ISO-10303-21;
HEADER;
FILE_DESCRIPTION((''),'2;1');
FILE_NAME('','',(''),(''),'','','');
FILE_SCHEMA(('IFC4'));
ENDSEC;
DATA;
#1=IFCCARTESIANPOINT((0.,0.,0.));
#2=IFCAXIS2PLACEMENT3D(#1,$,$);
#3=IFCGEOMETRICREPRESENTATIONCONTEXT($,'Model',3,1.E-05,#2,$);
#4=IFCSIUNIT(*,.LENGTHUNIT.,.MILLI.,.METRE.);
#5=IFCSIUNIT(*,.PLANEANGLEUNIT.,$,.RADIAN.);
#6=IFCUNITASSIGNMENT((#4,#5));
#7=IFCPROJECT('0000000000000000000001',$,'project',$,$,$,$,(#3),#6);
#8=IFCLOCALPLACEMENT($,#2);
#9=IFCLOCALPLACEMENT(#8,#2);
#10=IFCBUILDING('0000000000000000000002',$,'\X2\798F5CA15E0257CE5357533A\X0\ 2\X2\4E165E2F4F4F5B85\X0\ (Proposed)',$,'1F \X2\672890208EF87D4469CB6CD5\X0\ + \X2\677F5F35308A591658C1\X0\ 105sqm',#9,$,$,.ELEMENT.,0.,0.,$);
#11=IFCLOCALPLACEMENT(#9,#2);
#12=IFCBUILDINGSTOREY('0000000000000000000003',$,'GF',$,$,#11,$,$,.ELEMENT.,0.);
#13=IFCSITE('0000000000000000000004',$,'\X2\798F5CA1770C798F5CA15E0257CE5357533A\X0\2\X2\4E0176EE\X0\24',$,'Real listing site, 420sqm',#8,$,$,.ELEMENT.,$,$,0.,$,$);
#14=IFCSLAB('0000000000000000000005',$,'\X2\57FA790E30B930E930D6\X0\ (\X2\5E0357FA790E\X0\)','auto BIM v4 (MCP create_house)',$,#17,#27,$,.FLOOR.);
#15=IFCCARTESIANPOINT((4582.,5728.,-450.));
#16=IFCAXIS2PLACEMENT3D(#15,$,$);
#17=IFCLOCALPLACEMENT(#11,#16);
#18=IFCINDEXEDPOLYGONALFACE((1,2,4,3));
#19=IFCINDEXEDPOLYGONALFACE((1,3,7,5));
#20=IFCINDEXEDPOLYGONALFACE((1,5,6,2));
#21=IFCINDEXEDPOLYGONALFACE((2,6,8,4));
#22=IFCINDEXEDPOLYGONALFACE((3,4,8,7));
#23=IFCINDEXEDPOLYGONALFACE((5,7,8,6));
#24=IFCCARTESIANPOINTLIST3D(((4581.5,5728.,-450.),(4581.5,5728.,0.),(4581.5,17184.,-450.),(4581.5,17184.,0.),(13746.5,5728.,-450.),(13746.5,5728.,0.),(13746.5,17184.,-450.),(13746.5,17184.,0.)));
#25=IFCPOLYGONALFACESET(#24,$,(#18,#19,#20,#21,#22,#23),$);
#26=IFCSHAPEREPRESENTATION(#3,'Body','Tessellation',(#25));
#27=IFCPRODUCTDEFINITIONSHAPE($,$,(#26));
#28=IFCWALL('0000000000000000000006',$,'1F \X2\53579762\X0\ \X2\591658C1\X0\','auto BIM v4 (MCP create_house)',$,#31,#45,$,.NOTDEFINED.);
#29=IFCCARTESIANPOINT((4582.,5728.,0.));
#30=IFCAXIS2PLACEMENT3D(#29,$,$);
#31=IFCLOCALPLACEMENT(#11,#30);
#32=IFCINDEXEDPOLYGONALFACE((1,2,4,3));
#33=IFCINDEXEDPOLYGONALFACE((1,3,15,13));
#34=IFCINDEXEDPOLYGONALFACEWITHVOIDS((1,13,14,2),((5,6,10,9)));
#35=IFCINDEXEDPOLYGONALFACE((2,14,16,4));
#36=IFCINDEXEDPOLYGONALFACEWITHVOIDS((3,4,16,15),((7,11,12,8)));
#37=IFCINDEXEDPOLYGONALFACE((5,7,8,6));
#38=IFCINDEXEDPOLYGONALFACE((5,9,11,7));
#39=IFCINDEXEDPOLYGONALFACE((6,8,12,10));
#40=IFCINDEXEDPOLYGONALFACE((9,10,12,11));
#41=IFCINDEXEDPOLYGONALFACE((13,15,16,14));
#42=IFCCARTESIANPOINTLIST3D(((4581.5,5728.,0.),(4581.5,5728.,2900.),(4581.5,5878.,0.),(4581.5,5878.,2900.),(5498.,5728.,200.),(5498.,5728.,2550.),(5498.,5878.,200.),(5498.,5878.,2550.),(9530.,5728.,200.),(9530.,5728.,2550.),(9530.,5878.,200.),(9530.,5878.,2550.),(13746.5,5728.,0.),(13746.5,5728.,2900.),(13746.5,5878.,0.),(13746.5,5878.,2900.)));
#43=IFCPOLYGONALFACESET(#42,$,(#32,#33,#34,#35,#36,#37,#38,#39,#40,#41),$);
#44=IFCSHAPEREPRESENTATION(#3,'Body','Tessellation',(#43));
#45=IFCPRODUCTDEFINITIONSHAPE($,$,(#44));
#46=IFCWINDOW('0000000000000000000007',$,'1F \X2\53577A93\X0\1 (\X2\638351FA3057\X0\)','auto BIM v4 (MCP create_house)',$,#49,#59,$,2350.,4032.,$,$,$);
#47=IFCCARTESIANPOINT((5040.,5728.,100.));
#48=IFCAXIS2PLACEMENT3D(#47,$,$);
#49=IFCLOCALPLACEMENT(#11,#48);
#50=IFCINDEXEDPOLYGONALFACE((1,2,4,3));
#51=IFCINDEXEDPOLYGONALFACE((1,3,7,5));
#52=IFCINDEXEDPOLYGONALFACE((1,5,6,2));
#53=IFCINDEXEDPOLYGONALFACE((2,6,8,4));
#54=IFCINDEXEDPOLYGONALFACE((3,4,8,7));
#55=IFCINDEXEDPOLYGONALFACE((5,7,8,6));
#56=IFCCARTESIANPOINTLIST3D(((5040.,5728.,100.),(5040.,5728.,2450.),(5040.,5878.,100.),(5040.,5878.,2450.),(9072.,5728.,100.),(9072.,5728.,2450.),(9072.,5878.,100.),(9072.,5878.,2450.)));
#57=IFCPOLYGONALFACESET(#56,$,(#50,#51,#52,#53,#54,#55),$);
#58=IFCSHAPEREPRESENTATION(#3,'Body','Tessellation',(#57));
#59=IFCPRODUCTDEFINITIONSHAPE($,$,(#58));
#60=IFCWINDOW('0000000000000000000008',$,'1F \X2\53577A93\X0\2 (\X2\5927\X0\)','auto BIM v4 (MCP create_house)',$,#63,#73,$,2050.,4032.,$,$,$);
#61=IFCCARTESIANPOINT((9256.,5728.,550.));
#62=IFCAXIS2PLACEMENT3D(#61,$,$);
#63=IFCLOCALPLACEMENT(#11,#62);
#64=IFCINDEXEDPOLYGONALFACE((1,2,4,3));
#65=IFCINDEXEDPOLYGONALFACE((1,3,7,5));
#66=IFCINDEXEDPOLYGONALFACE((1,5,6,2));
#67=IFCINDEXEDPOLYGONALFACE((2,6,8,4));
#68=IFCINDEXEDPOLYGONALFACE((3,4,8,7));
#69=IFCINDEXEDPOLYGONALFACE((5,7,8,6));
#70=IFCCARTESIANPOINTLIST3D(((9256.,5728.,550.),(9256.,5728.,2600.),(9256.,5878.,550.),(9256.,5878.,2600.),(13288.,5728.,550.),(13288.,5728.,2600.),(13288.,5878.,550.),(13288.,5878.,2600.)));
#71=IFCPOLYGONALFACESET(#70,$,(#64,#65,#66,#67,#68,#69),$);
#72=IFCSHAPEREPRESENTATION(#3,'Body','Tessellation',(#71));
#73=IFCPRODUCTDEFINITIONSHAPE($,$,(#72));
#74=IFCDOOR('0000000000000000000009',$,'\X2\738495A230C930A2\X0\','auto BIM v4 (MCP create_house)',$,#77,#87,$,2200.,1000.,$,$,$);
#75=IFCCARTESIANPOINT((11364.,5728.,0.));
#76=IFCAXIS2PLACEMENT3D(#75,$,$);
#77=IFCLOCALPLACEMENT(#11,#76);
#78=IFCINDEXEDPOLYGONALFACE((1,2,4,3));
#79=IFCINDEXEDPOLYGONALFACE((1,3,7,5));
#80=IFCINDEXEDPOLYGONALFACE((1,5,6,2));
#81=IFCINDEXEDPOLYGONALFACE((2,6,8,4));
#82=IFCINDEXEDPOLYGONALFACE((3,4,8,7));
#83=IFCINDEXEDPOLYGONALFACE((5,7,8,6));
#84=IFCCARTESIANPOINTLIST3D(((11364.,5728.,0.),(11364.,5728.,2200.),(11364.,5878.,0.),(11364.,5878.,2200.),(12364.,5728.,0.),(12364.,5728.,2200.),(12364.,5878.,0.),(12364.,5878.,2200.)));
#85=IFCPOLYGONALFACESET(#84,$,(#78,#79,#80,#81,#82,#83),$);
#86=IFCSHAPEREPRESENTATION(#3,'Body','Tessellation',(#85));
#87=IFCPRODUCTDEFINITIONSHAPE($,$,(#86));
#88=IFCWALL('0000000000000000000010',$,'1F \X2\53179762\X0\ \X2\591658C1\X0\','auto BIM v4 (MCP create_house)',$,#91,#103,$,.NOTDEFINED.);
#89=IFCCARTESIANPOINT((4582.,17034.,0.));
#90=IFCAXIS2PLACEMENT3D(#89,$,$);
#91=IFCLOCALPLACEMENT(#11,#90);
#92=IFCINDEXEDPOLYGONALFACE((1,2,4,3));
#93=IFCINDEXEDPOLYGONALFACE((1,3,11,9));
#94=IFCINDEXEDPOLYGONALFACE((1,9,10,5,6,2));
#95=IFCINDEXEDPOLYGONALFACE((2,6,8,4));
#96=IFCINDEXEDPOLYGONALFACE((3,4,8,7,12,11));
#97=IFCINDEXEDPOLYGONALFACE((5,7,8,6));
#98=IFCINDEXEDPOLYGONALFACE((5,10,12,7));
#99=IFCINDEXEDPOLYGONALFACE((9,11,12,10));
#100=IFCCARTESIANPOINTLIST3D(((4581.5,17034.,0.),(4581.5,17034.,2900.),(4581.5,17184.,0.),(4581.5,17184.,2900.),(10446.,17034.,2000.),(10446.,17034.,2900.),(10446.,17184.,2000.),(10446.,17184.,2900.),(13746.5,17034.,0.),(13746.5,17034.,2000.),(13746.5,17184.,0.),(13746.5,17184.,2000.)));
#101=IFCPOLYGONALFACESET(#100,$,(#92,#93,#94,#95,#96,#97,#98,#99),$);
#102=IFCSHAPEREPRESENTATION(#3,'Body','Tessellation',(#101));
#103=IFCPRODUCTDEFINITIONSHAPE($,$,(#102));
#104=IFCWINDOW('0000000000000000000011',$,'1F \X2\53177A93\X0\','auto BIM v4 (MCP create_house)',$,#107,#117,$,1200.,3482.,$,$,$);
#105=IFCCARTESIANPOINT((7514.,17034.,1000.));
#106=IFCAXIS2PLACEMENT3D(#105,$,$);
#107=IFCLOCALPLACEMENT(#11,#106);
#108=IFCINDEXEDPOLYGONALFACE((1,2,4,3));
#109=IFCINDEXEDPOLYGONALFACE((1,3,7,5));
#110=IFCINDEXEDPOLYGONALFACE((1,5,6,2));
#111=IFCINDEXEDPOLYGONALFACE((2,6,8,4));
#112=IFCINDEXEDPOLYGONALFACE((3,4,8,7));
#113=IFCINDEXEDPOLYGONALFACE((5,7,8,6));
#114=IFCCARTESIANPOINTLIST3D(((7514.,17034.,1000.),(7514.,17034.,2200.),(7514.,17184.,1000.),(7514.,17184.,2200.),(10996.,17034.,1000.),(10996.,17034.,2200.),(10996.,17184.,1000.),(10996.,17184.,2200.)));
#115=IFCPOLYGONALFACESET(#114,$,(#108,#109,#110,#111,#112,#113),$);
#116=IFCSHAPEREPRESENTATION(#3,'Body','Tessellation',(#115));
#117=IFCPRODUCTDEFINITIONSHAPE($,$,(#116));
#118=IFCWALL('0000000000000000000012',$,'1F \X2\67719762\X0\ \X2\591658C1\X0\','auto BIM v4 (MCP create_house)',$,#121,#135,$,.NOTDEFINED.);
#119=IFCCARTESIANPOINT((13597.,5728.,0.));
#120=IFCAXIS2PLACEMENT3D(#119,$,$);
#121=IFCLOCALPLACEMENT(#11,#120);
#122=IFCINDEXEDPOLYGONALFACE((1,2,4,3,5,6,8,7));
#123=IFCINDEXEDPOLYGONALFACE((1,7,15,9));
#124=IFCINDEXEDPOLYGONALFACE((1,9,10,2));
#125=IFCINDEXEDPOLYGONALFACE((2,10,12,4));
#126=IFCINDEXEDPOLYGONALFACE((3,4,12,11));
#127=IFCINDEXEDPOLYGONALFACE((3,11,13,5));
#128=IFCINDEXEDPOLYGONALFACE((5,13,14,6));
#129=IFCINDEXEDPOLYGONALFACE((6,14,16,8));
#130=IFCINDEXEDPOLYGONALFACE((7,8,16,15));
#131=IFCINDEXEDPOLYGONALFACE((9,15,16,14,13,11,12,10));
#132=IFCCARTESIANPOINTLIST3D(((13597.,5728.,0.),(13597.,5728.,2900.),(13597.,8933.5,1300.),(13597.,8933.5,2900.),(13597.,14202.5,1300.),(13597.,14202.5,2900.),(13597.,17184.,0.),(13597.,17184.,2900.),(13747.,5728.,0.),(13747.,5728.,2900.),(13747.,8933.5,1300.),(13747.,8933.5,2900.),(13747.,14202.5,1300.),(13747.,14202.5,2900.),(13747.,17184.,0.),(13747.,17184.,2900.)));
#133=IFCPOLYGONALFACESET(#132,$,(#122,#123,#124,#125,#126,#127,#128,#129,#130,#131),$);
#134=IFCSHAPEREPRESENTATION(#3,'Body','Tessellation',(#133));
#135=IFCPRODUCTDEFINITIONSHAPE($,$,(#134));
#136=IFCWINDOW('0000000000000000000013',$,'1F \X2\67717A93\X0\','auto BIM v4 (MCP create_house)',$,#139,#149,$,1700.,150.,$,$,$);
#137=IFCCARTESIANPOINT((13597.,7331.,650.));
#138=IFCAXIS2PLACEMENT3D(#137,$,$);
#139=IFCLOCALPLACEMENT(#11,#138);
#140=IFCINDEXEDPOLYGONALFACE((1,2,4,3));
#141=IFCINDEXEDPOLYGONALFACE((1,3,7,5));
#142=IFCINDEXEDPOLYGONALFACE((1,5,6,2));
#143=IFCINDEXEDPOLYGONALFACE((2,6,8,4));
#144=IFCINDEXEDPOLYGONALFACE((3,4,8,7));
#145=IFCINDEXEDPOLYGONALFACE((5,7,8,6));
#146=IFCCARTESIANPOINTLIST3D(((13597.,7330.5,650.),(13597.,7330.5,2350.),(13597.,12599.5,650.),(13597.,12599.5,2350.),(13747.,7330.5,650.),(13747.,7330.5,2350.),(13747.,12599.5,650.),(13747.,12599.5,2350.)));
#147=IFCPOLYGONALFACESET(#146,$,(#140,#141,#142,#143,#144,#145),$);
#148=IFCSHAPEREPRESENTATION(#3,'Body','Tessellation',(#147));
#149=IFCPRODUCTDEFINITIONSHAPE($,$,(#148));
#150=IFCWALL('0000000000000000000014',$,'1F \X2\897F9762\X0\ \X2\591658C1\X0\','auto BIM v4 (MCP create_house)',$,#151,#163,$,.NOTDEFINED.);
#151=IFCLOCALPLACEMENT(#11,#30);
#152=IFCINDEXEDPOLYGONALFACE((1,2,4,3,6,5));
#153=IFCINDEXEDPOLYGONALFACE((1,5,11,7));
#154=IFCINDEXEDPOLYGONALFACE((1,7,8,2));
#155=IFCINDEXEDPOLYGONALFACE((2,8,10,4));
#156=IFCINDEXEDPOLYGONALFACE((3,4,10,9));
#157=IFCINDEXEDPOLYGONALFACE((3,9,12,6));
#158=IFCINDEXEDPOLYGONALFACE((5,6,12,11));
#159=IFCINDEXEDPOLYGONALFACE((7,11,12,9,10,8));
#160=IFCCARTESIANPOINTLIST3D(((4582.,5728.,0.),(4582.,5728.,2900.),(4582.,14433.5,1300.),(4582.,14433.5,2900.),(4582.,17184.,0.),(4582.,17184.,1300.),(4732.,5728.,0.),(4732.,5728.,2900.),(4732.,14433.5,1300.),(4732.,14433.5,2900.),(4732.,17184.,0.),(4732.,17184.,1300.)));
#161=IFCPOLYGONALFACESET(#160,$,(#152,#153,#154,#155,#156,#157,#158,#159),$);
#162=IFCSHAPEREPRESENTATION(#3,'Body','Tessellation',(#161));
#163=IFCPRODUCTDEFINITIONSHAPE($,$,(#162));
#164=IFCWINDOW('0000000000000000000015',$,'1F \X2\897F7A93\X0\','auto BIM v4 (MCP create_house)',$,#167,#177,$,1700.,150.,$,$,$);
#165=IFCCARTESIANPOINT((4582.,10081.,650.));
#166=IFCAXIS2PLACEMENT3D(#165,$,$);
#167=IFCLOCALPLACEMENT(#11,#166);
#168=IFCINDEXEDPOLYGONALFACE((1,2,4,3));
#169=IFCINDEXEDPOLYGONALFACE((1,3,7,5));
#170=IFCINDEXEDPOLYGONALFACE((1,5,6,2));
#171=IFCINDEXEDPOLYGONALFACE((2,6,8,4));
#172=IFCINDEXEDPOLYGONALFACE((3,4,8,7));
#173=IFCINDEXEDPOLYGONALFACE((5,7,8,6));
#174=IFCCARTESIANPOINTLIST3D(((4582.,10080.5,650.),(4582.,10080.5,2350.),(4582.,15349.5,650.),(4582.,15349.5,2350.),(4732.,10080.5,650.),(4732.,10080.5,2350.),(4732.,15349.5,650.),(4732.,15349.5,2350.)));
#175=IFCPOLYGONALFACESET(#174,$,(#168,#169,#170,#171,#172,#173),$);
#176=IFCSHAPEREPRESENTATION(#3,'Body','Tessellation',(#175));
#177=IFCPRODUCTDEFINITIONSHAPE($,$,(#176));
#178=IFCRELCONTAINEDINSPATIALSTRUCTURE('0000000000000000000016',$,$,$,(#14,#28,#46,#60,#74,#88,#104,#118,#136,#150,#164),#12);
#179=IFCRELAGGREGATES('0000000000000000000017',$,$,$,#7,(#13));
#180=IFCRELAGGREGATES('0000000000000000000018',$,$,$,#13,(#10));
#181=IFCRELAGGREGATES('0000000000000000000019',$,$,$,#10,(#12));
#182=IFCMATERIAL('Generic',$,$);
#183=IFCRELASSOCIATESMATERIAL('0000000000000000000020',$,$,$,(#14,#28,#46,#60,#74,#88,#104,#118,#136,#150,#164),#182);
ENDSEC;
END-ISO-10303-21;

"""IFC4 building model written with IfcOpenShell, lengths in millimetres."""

from ifc_helpers import new_model, si_unit, frame, frame_2d, origin, place, context, project, spatial, rectangle, extrude, material, element, fill, save


model = new_model("IFC4")

# Units and contexts
model_context = context("Model", 3, precision=1e-05, world=origin())
ifc_project = project(units=[si_unit("LENGTHUNIT", "METRE", prefix="MILLI"), si_unit("PLANEANGLEUNIT", "RADIAN")], contexts=[model_context])

# Site, building, storey
site_placement = place(None, origin())
site = spatial("IfcSite", under=ifc_project, at=site_placement, Name="福岡県福岡市城南区2丁目24", ObjectType="Real listing site, 420sqm", CompositionType="ELEMENT", RefElevation=0.0)
building_placement = place(site_placement, origin())
building = spatial("IfcBuilding", under=site, at=building_placement, Name="福岡市城南区 2世帯住宅 (Proposed)", ObjectType="1F 木造軸組構法 + 板張り外壁 105sqm", CompositionType="ELEMENT", ElevationOfRefHeight=0.0, ElevationOfTerrain=0.0)
storey_placement = place(building_placement, origin())
storey = spatial("IfcBuildingStorey", under=building, at=storey_placement, Name="GF", CompositionType="ELEMENT", Elevation=0.0)

# Slab
ifc_material = material(Name="Generic")
slab_1_placement = place(storey_placement, frame((4582.0, 5728.0, -450.0)))
element("IfcSlab", 1, at=slab_1_placement, inside=storey, material=ifc_material, Name="基礎スラブ (布基礎)", Description="auto BIM v4 (MCP create_house)", PredefinedType="FLOOR", context=model_context, shape_type="SweptSolid", body=[
    extrude(rectangle(XDim=9165.0, YDim=11456.0, at=frame_2d((4582.0, 5728.0))), frame((4582.0, 5728.0, -450.0)), (0.0, 0.0, 1.0), 450.0),
])

# Wall, openings, windows, door
wall_1_placement = place(storey_placement, frame((4582.0, 5728.0, 0.0)))
wall_1 = element("IfcWall", 2, at=wall_1_placement, inside=storey, material=ifc_material, Name="1F 南面 外壁", Description="auto BIM v4 (MCP create_house)", PredefinedType="NOTDEFINED", context=model_context, shape_type="SweptSolid", body=[
    extrude(rectangle(XDim=9165.0, YDim=150.0, at=frame_2d((4582.0, 75.0))), frame((4582.0, 5728.0, 0.0)), (0.0, 0.0, 1.0), 2900.0),
])
opening_1_placement = place(storey_placement, frame((5040.0, 5728.0, 100.0)))
opening_1 = element("IfcOpeningElement", 3, at=opening_1_placement, cuts=wall_1, PredefinedType="NOTDEFINED", context=model_context, shape_type="SweptSolid", body=[
    extrude(rectangle(XDim=4032.0, YDim=150.0, at=frame_2d((2016.0, 75.0))), frame((5040.0, 5728.0, 100.0)), (0.0, 0.0, 1.0), 2350.0),
])
opening_2_placement = place(storey_placement, frame((9256.0, 5728.0, 550.0)))
opening_2 = element("IfcOpeningElement", 4, at=opening_2_placement, cuts=wall_1, PredefinedType="NOTDEFINED", context=model_context, shape_type="SweptSolid", body=[
    extrude(rectangle(XDim=4032.0, YDim=150.0, at=frame_2d((2016.0, 75.0))), frame((9256.0, 5728.0, 550.0)), (0.0, 0.0, 1.0), 2050.0),
])
opening_3_placement = place(storey_placement, frame((11364.0, 5728.0, 0.0)))
opening_3 = element("IfcOpeningElement", 5, at=opening_3_placement, cuts=wall_1, PredefinedType="NOTDEFINED", context=model_context, shape_type="SweptSolid", body=[
    extrude(rectangle(XDim=1000.0, YDim=150.0, at=frame_2d((500.0, 75.0))), frame((11364.0, 5728.0, 0.0)), (0.0, 0.0, 1.0), 2200.0),
])
window_1_placement = place(storey_placement, frame((5040.0, 5728.0, 100.0)))
window_1 = element("IfcWindow", 6, at=window_1_placement, inside=storey, material=ifc_material, Name="1F 南窓1 (掃出し)", Description="auto BIM v4 (MCP create_house)", OverallHeight=2350.0, OverallWidth=4032.0, context=model_context, shape_type="SweptSolid", body=[
    extrude(rectangle(XDim=4032.0, YDim=150.0, at=frame_2d((2016.0, 75.0))), frame((5040.0, 5728.0, 100.0)), (0.0, 0.0, 1.0), 2350.0),
])
fill(opening_1, window_1)
window_2_placement = place(storey_placement, frame((9256.0, 5728.0, 550.0)))
window_2 = element("IfcWindow", 7, at=window_2_placement, inside=storey, material=ifc_material, Name="1F 南窓2 (大)", Description="auto BIM v4 (MCP create_house)", OverallHeight=2050.0, OverallWidth=4032.0, context=model_context, shape_type="SweptSolid", body=[
    extrude(rectangle(XDim=4032.0, YDim=150.0, at=frame_2d((2016.0, 75.0))), frame((9256.0, 5728.0, 550.0)), (0.0, 0.0, 1.0), 2050.0),
])
fill(opening_2, window_2)
door_placement = place(storey_placement, frame((11364.0, 5728.0, 0.0)))
door = element("IfcDoor", 8, at=door_placement, inside=storey, material=ifc_material, Name="玄関ドア", Description="auto BIM v4 (MCP create_house)", OverallHeight=2200.0, OverallWidth=1000.0, context=model_context, shape_type="SweptSolid", body=[
    extrude(rectangle(XDim=1000.0, YDim=150.0, at=frame_2d((500.0, 75.0))), frame((11364.0, 5728.0, 0.0)), (0.0, 0.0, 1.0), 2200.0),
])
fill(opening_3, door)

# Walls, openings, windows
wall_2_placement = place(storey_placement, frame((4582.0, 17034.0, 0.0)))
wall_2 = element("IfcWall", 9, at=wall_2_placement, inside=storey, material=ifc_material, Name="1F 北面 外壁", Description="auto BIM v4 (MCP create_house)", PredefinedType="NOTDEFINED", context=model_context, shape_type="SweptSolid", body=[
    extrude(rectangle(XDim=9165.0, YDim=150.0, at=frame_2d((4582.0, 75.0))), frame((4582.0, 17034.0, 0.0)), (0.0, 0.0, 1.0), 2900.0),
])
opening_4_placement = place(storey_placement, frame((7514.0, 17034.0, 1000.0)))
opening_4 = element("IfcOpeningElement", 10, at=opening_4_placement, cuts=wall_2, PredefinedType="NOTDEFINED", context=model_context, shape_type="SweptSolid", body=[
    extrude(rectangle(XDim=3482.0, YDim=150.0, at=frame_2d((1741.0, 75.0))), frame((7514.0, 17034.0, 1000.0)), (0.0, 0.0, 1.0), 1200.0),
])
window_3_placement = place(storey_placement, frame((7514.0, 17034.0, 1000.0)))
window_3 = element("IfcWindow", 11, at=window_3_placement, inside=storey, material=ifc_material, Name="1F 北窓", Description="auto BIM v4 (MCP create_house)", OverallHeight=1200.0, OverallWidth=3482.0, context=model_context, shape_type="SweptSolid", body=[
    extrude(rectangle(XDim=3482.0, YDim=150.0, at=frame_2d((1741.0, 75.0))), frame((7514.0, 17034.0, 1000.0)), (0.0, 0.0, 1.0), 1200.0),
])
fill(opening_4, window_3)
wall_3_placement = place(storey_placement, frame((13597.0, 5728.0, 0.0)))
wall_3 = element("IfcWall", 12, at=wall_3_placement, inside=storey, material=ifc_material, Name="1F 東面 外壁", Description="auto BIM v4 (MCP create_house)", PredefinedType="NOTDEFINED", context=model_context, shape_type="SweptSolid", body=[
    extrude(rectangle(XDim=150.0, YDim=11456.0, at=frame_2d((75.0, 5728.0))), frame((13597.0, 5728.0, 0.0)), (0.0, 0.0, 1.0), 2900.0),
])
opening_5_placement = place(storey_placement, frame((13597.0, 7331.0, 650.0)))
opening_5 = element("IfcOpeningElement", 13, at=opening_5_placement, cuts=wall_3, PredefinedType="NOTDEFINED", context=model_context, shape_type="SweptSolid", body=[
    extrude(rectangle(XDim=150.0, YDim=5269.0, at=frame_2d((75.0, 2634.0))), frame((13597.0, 7331.0, 650.0)), (0.0, 0.0, 1.0), 1700.0),
])
window_4_placement = place(storey_placement, frame((13597.0, 7331.0, 650.0)))
window_4 = element("IfcWindow", 14, at=window_4_placement, inside=storey, material=ifc_material, Name="1F 東窓", Description="auto BIM v4 (MCP create_house)", OverallHeight=1700.0, OverallWidth=150.0, context=model_context, shape_type="SweptSolid", body=[
    extrude(rectangle(XDim=150.0, YDim=5269.0, at=frame_2d((75.0, 2634.0))), frame((13597.0, 7331.0, 650.0)), (0.0, 0.0, 1.0), 1700.0),
])
fill(opening_5, window_4)
wall_4_placement = place(storey_placement, frame((4582.0, 5728.0, 0.0)))
wall_4 = element("IfcWall", 15, at=wall_4_placement, inside=storey, material=ifc_material, Name="1F 西面 外壁", Description="auto BIM v4 (MCP create_house)", PredefinedType="NOTDEFINED", context=model_context, shape_type="SweptSolid", body=[
    extrude(rectangle(XDim=150.0, YDim=11456.0, at=frame_2d((75.0, 5728.0))), frame((4582.0, 5728.0, 0.0)), (0.0, 0.0, 1.0), 2900.0),
])
opening_6_placement = place(storey_placement, frame((4582.0, 10081.0, 650.0)))
opening_6 = element("IfcOpeningElement", 16, at=opening_6_placement, cuts=wall_4, PredefinedType="NOTDEFINED", context=model_context, shape_type="SweptSolid", body=[
    extrude(rectangle(XDim=150.0, YDim=5269.0, at=frame_2d((75.0, 2634.0))), frame((4582.0, 10081.0, 650.0)), (0.0, 0.0, 1.0), 1700.0),
])
window_5_placement = place(storey_placement, frame((4582.0, 10081.0, 650.0)))
window_5 = element("IfcWindow", 17, at=window_5_placement, inside=storey, material=ifc_material, Name="1F 西窓", Description="auto BIM v4 (MCP create_house)", OverallHeight=1700.0, OverallWidth=150.0, context=model_context, shape_type="SweptSolid", body=[
    extrude(rectangle(XDim=150.0, YDim=5269.0, at=frame_2d((75.0, 2634.0))), frame((4582.0, 10081.0, 650.0)), (0.0, 0.0, 1.0), 1700.0),
])
fill(opening_6, window_5)

save(model, "model.ifc")
